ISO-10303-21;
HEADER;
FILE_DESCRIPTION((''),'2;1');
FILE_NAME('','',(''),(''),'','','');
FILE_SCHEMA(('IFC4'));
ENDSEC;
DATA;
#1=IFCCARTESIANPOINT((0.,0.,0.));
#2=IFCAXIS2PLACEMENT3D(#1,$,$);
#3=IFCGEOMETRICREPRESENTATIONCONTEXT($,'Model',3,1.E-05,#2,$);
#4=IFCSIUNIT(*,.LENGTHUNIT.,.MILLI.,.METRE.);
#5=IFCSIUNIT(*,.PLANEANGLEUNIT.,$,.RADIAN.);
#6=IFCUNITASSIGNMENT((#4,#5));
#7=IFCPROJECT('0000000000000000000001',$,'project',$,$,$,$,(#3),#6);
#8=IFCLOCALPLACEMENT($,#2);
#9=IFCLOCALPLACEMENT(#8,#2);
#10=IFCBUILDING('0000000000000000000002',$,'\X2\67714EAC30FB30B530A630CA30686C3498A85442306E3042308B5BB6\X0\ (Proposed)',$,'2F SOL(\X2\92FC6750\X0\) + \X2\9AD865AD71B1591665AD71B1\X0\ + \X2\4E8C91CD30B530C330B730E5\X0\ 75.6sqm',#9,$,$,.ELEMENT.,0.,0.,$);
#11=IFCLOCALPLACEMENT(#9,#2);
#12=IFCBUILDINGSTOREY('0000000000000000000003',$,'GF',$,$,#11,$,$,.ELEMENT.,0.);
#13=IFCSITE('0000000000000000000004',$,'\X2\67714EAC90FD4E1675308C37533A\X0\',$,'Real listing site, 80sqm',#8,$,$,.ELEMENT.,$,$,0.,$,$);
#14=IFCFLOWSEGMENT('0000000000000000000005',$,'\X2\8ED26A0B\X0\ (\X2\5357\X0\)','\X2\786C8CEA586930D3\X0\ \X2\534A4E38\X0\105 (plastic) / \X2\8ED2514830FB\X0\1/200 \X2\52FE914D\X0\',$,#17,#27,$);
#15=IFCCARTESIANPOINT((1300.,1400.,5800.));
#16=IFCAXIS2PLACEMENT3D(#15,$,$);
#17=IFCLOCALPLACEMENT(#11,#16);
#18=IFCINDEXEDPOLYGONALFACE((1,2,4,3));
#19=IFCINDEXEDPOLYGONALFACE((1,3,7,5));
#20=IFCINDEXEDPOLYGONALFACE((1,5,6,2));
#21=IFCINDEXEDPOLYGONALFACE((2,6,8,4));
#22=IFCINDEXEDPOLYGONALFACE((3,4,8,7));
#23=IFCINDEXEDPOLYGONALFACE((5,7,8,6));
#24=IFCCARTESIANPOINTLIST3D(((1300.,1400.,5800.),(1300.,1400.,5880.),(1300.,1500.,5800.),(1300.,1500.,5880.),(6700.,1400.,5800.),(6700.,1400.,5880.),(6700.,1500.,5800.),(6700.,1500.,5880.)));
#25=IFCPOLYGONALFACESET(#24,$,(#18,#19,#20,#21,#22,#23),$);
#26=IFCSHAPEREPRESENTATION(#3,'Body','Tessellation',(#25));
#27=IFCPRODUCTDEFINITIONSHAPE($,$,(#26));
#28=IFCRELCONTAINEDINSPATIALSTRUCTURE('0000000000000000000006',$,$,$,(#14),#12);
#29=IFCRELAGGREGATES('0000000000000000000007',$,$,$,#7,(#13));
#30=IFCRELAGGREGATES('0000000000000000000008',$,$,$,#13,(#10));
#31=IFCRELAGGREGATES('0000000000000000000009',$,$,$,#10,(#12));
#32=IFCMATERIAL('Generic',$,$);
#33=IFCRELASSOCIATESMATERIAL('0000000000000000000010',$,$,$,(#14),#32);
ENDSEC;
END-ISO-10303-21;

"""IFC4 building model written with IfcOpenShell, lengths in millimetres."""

from ifc_helpers import new_model, si_unit, frame, frame_2d, origin, place, context, project, spatial, rectangle, extrude, material, element, save


model = new_model("IFC4")

# Units and contexts
model_context = context("Model", 3, precision=1e-05, world=origin())
ifc_project = project(units=[si_unit("LENGTHUNIT", "METRE", prefix="MILLI"), si_unit("PLANEANGLEUNIT", "RADIAN")], contexts=[model_context])

# Site, building, storey
site_placement = place(None, origin())
site = spatial("IfcSite", under=ifc_project, at=site_placement, Name="東京都世田谷区", ObjectType="Real listing site, 80sqm", CompositionType="ELEMENT", RefElevation=0.0)
building_placement = place(site_placement, origin())
building = spatial("IfcBuilding", under=site, at=building_placement, Name="東京・サウナと水風呂のある家 (Proposed)", ObjectType="2F SOL(鋼材) + 高断熱外断熱 + 二重サッシュ 75.6sqm", CompositionType="ELEMENT", ElevationOfRefHeight=0.0, ElevationOfTerrain=0.0)
storey_placement = place(building_placement, origin())
storey = spatial("IfcBuildingStorey", under=building, at=storey_placement, Name="GF", CompositionType="ELEMENT", Elevation=0.0)

# Flow segment
ifc_material_1 = material(Name="Generic")
flow_segment_placement = place(storey_placement, frame((1300.0, 1400.0, 5800.0)))
element("IfcFlowSegment", 1, at=flow_segment_placement, inside=storey, material=ifc_material_1, Name="軒樋 (南)", Description="硬質塩ビ 半丸105 (plastic) / 軒先・1/200 勾配", context=model_context, shape_type="SweptSolid", body=[
    extrude(rectangle(XDim=5400.0, YDim=100.0, at=frame_2d((2700.0, 50.0))), frame((1300.0, 1400.0, 5800.0)), (0.0, 0.0, 1.0), 80.0),
])

save(model, "model.ifc")
